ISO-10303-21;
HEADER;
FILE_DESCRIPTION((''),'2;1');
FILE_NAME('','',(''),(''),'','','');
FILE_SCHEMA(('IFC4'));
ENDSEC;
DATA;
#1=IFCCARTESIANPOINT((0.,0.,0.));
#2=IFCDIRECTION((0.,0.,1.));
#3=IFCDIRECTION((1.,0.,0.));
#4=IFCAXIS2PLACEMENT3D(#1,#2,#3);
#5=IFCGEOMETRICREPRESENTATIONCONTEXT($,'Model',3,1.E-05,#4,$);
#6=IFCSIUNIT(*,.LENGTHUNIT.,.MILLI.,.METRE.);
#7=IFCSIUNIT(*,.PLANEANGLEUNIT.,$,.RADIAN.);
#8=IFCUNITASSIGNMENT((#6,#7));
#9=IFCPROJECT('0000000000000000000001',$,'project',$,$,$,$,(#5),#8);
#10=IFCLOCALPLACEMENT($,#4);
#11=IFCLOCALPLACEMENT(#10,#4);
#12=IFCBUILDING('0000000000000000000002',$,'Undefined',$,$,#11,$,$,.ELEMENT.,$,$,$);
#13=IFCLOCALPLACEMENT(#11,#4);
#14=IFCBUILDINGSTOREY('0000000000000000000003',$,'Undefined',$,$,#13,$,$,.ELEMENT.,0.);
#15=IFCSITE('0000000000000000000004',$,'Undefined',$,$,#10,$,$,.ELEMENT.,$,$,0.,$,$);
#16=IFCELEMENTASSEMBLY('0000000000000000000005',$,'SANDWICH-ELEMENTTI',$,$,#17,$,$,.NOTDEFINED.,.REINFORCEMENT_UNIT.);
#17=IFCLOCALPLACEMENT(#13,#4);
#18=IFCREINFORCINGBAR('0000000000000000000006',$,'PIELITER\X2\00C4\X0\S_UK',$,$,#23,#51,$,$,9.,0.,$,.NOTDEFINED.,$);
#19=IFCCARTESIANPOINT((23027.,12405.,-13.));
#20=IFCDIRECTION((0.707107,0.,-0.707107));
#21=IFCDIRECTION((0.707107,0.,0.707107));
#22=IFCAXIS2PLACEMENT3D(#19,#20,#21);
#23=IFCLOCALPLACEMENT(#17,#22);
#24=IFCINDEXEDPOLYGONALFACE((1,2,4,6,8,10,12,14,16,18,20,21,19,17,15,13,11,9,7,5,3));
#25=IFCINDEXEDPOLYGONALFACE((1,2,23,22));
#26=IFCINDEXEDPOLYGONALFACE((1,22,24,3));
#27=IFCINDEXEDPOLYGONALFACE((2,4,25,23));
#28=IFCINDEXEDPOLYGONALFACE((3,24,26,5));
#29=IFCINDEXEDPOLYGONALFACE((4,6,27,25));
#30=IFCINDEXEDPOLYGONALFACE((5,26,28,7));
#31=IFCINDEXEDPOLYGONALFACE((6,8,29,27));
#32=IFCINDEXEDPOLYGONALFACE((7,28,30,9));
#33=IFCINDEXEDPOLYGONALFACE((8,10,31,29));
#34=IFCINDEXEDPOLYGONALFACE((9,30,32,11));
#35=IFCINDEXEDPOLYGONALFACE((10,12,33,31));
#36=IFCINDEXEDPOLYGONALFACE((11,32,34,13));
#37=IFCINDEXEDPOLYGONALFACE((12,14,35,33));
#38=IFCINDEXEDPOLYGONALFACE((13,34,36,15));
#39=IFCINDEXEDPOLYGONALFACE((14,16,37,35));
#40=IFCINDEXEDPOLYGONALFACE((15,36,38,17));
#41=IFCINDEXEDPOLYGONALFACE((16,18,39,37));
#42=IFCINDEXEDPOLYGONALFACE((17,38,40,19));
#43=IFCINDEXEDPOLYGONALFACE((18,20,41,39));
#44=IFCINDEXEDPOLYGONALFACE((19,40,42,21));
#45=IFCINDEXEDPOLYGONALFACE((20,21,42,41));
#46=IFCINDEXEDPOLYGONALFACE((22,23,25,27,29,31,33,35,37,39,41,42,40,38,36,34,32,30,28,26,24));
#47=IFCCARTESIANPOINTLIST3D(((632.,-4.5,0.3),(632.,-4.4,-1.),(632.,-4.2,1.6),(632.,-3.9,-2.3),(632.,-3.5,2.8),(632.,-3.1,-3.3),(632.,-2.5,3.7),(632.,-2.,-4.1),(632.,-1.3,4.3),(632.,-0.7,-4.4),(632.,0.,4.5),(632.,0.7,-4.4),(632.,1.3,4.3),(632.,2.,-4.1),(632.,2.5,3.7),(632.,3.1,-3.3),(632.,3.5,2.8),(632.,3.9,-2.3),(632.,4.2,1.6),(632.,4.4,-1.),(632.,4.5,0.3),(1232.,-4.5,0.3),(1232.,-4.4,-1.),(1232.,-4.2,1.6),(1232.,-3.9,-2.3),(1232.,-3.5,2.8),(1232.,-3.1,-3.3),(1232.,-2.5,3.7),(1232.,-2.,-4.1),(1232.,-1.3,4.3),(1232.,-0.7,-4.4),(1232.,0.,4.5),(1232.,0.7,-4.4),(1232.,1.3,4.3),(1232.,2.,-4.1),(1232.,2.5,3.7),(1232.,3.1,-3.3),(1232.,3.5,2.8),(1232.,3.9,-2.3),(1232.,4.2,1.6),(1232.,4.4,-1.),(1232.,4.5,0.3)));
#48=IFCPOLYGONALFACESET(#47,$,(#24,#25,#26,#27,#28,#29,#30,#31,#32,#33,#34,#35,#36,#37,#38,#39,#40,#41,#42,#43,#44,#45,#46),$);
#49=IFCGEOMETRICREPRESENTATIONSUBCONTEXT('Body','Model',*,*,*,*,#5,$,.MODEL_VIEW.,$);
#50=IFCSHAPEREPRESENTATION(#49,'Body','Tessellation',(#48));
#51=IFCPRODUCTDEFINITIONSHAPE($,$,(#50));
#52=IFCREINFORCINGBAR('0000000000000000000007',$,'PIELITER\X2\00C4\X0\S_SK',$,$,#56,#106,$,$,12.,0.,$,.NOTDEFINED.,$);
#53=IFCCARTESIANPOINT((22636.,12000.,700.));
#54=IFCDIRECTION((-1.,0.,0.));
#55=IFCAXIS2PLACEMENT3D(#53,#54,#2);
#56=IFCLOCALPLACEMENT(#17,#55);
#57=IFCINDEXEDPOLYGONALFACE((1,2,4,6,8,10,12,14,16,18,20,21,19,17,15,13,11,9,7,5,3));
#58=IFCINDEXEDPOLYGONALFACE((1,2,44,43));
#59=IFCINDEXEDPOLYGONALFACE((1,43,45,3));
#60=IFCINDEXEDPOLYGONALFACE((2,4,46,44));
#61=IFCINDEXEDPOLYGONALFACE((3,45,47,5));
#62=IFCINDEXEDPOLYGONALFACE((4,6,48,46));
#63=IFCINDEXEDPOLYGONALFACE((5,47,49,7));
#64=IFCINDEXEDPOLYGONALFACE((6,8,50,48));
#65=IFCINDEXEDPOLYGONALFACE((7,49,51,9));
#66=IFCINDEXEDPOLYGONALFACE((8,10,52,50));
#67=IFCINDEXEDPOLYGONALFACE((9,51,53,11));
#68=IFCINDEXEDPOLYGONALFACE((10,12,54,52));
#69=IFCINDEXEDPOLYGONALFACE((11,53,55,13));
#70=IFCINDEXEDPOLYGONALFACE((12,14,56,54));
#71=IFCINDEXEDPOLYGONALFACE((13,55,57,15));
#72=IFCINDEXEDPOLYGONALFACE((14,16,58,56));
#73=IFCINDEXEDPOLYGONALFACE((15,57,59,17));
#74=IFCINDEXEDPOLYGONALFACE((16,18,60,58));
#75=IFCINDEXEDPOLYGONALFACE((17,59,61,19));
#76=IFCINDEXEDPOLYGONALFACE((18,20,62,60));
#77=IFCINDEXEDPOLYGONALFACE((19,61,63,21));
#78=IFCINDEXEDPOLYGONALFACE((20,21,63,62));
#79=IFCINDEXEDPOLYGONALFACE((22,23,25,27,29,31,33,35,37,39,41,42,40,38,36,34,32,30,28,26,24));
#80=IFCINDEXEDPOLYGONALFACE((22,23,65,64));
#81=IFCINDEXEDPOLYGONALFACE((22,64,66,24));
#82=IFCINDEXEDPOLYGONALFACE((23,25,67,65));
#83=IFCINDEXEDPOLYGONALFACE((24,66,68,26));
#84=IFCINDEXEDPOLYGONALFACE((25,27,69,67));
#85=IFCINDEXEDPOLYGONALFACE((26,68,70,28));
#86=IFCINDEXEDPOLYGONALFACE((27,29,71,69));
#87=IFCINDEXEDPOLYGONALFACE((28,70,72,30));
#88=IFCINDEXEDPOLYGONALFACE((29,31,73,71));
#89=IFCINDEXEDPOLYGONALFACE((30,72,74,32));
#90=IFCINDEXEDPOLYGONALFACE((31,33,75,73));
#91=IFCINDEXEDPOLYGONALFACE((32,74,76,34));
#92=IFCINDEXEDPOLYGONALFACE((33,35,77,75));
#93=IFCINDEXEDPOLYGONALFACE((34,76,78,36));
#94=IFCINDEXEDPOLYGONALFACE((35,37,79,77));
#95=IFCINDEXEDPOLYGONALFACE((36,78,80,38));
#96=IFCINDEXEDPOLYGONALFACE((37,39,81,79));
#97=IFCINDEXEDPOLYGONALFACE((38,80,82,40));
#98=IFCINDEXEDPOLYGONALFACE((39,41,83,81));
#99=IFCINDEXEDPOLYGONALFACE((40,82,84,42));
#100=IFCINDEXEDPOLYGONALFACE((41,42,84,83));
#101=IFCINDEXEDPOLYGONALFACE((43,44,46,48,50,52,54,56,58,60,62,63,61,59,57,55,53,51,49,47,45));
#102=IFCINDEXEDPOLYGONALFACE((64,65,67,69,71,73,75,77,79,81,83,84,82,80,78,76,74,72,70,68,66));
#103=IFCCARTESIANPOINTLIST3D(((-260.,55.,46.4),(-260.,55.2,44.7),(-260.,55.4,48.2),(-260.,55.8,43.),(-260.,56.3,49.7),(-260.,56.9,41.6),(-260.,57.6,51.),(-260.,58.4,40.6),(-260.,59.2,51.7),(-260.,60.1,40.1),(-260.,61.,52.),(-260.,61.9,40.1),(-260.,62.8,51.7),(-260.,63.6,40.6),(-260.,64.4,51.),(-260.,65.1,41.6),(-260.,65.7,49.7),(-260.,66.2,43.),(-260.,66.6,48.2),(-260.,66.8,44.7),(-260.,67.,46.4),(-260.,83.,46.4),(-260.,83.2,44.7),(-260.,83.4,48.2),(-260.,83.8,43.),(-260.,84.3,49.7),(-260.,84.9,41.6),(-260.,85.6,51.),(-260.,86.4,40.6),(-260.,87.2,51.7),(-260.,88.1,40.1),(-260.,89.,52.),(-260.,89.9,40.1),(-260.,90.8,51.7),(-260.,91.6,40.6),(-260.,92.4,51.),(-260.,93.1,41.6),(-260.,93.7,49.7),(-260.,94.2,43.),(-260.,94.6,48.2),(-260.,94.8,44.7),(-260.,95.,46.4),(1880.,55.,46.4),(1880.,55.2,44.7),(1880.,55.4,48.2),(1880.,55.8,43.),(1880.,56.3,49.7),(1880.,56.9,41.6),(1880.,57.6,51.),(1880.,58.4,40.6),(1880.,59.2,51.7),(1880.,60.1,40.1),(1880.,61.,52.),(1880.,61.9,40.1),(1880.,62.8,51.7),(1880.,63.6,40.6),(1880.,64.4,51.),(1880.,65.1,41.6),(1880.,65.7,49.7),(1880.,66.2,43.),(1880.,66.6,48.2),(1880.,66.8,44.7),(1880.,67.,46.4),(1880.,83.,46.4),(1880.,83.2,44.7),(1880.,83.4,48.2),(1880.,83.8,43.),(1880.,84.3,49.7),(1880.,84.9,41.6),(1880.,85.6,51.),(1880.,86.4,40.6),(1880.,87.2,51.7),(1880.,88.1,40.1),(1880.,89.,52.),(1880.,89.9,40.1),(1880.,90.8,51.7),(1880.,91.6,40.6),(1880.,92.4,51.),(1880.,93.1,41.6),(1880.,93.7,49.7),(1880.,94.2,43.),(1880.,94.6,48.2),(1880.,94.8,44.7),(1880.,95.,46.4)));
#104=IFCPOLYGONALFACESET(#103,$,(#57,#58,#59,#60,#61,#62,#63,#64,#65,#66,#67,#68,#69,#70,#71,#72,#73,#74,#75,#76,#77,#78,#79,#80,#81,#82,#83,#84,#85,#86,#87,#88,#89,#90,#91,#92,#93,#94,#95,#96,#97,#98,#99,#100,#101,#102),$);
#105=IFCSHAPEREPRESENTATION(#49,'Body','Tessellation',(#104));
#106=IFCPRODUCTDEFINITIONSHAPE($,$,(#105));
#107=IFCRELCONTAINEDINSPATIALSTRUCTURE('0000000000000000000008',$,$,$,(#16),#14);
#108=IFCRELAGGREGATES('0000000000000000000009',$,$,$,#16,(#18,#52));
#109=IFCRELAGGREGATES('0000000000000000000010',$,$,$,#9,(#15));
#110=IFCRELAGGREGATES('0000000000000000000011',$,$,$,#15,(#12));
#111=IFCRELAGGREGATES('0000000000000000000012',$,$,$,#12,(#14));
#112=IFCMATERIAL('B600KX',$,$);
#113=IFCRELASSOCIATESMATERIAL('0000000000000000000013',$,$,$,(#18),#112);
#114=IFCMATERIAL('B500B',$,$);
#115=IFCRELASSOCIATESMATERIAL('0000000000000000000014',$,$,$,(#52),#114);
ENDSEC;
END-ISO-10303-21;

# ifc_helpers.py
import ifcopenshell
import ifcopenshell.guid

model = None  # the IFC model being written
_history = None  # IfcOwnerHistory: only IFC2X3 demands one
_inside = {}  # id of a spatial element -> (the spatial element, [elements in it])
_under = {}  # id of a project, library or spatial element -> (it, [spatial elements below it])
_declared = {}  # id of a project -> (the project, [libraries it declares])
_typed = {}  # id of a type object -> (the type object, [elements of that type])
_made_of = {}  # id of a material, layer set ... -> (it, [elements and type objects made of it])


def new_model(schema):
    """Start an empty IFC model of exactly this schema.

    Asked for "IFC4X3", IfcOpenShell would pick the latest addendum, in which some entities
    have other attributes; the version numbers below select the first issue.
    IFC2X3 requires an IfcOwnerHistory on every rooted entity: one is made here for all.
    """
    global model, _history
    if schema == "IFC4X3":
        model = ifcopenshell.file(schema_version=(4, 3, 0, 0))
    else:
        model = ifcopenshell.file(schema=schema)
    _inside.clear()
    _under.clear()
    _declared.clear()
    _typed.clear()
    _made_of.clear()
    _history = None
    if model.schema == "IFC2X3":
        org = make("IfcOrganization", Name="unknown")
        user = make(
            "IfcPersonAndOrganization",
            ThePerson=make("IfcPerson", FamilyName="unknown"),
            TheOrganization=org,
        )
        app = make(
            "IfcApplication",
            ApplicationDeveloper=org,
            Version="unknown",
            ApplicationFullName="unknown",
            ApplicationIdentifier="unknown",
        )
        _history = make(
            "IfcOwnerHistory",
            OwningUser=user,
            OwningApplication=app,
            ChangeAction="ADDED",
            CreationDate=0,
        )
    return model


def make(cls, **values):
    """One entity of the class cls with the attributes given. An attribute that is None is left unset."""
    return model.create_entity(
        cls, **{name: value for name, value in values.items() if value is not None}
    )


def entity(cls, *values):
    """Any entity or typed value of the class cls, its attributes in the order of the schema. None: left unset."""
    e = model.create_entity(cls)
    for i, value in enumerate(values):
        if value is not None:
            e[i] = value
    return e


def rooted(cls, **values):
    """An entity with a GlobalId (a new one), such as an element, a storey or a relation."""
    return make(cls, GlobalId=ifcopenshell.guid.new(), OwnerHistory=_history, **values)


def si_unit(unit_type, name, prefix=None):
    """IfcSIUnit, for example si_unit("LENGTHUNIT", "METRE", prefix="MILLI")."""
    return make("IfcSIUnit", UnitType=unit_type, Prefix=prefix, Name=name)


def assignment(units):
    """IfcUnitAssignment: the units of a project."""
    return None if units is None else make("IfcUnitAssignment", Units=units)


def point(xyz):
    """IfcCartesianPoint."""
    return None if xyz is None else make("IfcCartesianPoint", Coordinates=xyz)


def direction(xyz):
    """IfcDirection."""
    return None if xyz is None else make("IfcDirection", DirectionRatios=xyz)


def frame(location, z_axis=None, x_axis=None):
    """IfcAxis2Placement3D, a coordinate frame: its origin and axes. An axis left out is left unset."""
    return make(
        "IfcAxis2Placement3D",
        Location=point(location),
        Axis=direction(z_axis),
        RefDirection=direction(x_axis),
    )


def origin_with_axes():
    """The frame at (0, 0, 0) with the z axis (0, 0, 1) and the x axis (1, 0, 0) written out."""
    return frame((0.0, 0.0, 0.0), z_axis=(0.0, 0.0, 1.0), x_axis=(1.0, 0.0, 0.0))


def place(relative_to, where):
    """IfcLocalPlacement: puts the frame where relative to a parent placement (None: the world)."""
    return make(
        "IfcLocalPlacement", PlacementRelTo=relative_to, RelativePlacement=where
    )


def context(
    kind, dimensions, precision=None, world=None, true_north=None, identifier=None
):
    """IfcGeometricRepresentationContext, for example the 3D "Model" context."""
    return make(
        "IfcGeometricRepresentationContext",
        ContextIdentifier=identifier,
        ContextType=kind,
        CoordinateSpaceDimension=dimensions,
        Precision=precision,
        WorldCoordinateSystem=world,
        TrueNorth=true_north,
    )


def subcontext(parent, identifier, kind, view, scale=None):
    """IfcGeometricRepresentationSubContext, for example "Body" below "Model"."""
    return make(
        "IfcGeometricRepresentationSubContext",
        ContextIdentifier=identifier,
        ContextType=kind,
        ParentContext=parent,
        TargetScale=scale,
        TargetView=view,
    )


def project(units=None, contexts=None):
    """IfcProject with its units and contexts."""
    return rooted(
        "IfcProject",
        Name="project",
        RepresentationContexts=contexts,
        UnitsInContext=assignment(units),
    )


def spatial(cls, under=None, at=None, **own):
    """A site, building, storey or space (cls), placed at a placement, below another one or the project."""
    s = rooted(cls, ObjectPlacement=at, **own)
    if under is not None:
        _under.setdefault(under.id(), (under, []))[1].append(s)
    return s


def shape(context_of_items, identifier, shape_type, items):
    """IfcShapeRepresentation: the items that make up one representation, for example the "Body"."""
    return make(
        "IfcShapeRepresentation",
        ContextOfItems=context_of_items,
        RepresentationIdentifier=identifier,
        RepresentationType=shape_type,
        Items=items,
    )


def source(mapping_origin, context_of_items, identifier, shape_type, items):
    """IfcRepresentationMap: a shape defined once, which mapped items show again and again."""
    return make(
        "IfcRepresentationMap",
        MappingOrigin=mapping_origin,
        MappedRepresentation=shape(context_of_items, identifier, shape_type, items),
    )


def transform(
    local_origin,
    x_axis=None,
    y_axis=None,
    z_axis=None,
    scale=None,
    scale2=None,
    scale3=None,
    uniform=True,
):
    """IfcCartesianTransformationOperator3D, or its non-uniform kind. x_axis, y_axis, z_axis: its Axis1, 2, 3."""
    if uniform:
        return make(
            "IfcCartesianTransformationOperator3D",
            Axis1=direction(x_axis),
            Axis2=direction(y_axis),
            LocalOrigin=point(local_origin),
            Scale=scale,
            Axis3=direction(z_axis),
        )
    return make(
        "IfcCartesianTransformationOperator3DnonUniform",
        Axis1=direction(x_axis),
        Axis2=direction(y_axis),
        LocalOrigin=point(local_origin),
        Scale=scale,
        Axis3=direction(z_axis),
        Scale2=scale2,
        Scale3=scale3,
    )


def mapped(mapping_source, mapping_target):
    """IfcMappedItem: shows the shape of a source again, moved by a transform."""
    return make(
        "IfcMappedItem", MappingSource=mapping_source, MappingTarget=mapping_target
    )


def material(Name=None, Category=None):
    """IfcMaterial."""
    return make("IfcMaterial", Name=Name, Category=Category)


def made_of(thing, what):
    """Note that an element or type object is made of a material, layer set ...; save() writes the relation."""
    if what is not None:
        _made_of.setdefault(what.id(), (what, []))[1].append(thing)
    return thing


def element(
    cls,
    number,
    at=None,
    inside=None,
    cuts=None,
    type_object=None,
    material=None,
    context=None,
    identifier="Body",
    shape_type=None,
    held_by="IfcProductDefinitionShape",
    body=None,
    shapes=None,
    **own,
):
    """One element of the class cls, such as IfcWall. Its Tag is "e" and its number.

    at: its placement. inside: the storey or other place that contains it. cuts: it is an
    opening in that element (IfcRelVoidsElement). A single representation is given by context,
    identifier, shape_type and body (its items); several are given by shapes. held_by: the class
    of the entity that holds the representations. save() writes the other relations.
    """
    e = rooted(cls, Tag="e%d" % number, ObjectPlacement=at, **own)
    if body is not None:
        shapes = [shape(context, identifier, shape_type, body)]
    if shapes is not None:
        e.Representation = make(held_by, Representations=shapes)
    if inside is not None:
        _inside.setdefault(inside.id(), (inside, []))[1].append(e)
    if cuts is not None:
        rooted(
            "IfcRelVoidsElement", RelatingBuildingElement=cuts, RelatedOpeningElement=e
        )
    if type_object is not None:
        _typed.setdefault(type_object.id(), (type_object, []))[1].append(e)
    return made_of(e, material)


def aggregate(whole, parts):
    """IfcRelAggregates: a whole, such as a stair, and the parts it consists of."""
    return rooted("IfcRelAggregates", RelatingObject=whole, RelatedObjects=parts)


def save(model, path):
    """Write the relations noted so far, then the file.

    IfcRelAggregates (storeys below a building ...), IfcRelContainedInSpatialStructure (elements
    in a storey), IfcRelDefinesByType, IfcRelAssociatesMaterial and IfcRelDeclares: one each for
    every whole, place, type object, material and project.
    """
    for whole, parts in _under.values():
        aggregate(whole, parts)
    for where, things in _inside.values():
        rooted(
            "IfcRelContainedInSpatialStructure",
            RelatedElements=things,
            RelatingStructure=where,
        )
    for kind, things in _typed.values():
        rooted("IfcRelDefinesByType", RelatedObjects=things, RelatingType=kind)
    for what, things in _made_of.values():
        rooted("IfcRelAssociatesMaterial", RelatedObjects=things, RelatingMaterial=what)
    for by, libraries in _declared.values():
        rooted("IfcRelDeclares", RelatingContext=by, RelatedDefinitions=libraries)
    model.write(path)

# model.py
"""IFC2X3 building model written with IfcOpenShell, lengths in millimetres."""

from ifc_helpers import new_model, entity, si_unit, frame, origin_with_axes, place, context, subcontext, project, spatial, source, transform, mapped, material, element, aggregate, save


model = new_model("IFC2X3")

# Units and contexts
model_context = context("Model", 3, precision=1e-05, world=origin_with_axes())
body_context = subcontext(model_context, "Body", "Model", "MODEL_VIEW")
ifc_project = project(units=[si_unit("LENGTHUNIT", "METRE", prefix="MILLI"), si_unit("PLANEANGLEUNIT", "RADIAN")], contexts=[model_context])

# Site, building, storey
site_placement = place(None, origin_with_axes())
site = spatial("IfcSite", under=ifc_project, at=site_placement, Name="Undefined", CompositionType="ELEMENT", RefElevation=0.0)
building_placement = place(site_placement, origin_with_axes())
building = spatial("IfcBuilding", under=site, at=building_placement, Name="Undefined", CompositionType="ELEMENT")
storey_placement = place(building_placement, origin_with_axes())
storey = spatial("IfcBuildingStorey", under=building, at=storey_placement, Name="Undefined", CompositionType="ELEMENT", Elevation=0.0)

# Element assembly
assembly_1_placement = place(storey_placement, origin_with_axes())
assembly_1 = element("IfcElementAssembly", 1, at=assembly_1_placement, inside=storey, Name="SANDWICH-ELEMENTTI", AssemblyPlace="NOTDEFINED", PredefinedType="REINFORCEMENT_UNIT")

# Reinforcing bars
ifc_material_1 = material(Name="B600KX")
shared_shape_1 = source(origin_with_axes(), body_context, "Body", "AdvancedSweptSolid", [
    entity("IfcSweptDiskSolid", entity("IfcTrimmedCurve", entity("IfcLine", entity("IfcCartesianPoint", [0.0, 0.0, 0.0]), entity("IfcVector", entity("IfcDirection", [1.0, 0.0, 0.0]), 1.0)), [entity("IfcParameterValue", 0.0)], [entity("IfcParameterValue", 600.0)], True, "PARAMETER"), 4.5, None, 0.0, 600.0),
])
reinforcing_bar_1_placement = place(assembly_1_placement, frame((23027.0, 12405.0, -13.0), z_axis=(0.707107, 0.0, -0.707107), x_axis=(0.707107, 0.0, 0.707107)))
reinforcing_bar_1 = element("IfcReinforcingBar", 2, at=reinforcing_bar_1_placement, material=ifc_material_1, Name="PIELITERÄS_UK", BarRole="NOTDEFINED", CrossSectionArea=0.0, NominalDiameter=9.0, context=body_context, shape_type="MappedRepresentation", body=[
    mapped(shared_shape_1, transform((632.0, 0.0, 0.0))),
])
ifc_material_2 = material(Name="B500B")
shared_shape_2 = source(origin_with_axes(), body_context, "Body", "AdvancedSweptSolid", [
    entity("IfcSweptDiskSolid", entity("IfcTrimmedCurve", entity("IfcLine", entity("IfcCartesianPoint", [0.0, 0.0, 0.0]), entity("IfcVector", entity("IfcDirection", [1.0, 0.0, 0.0]), 1.0)), [entity("IfcParameterValue", 0.0)], [entity("IfcParameterValue", 2140.0)], True, "PARAMETER"), 6.0, None, 0.0, 2140.0),
])
shared_shape_3 = source(origin_with_axes(), body_context, "Body", "AdvancedSweptSolid", [
    entity("IfcSweptDiskSolid", entity("IfcTrimmedCurve", entity("IfcLine", entity("IfcCartesianPoint", [0.0, 0.0, 0.0]), entity("IfcVector", entity("IfcDirection", [1.0, 0.0, 0.0]), 1.0)), [entity("IfcParameterValue", 0.0)], [entity("IfcParameterValue", 2140.0)], True, "PARAMETER"), 6.0, None, 0.0, 2140.0),
])
reinforcing_bar_2_placement = place(assembly_1_placement, frame((22636.0, 12000.0, 700.0), z_axis=(-1.0, 0.0, 0.0), x_axis=(0.0, 0.0, 1.0)))
reinforcing_bar_2 = element("IfcReinforcingBar", 3, at=reinforcing_bar_2_placement, material=ifc_material_2, Name="PIELITERÄS_SK", BarRole="NOTDEFINED", CrossSectionArea=0.0, NominalDiameter=12.0, context=body_context, shape_type="MappedRepresentation", body=[
    mapped(shared_shape_2, transform((-260.0, 61.0, 46.0))),
    mapped(shared_shape_3, transform((-260.0, 89.0, 46.0))),
])
aggregate(assembly_1, [reinforcing_bar_1, reinforcing_bar_2])

save(model, "model.ifc")
